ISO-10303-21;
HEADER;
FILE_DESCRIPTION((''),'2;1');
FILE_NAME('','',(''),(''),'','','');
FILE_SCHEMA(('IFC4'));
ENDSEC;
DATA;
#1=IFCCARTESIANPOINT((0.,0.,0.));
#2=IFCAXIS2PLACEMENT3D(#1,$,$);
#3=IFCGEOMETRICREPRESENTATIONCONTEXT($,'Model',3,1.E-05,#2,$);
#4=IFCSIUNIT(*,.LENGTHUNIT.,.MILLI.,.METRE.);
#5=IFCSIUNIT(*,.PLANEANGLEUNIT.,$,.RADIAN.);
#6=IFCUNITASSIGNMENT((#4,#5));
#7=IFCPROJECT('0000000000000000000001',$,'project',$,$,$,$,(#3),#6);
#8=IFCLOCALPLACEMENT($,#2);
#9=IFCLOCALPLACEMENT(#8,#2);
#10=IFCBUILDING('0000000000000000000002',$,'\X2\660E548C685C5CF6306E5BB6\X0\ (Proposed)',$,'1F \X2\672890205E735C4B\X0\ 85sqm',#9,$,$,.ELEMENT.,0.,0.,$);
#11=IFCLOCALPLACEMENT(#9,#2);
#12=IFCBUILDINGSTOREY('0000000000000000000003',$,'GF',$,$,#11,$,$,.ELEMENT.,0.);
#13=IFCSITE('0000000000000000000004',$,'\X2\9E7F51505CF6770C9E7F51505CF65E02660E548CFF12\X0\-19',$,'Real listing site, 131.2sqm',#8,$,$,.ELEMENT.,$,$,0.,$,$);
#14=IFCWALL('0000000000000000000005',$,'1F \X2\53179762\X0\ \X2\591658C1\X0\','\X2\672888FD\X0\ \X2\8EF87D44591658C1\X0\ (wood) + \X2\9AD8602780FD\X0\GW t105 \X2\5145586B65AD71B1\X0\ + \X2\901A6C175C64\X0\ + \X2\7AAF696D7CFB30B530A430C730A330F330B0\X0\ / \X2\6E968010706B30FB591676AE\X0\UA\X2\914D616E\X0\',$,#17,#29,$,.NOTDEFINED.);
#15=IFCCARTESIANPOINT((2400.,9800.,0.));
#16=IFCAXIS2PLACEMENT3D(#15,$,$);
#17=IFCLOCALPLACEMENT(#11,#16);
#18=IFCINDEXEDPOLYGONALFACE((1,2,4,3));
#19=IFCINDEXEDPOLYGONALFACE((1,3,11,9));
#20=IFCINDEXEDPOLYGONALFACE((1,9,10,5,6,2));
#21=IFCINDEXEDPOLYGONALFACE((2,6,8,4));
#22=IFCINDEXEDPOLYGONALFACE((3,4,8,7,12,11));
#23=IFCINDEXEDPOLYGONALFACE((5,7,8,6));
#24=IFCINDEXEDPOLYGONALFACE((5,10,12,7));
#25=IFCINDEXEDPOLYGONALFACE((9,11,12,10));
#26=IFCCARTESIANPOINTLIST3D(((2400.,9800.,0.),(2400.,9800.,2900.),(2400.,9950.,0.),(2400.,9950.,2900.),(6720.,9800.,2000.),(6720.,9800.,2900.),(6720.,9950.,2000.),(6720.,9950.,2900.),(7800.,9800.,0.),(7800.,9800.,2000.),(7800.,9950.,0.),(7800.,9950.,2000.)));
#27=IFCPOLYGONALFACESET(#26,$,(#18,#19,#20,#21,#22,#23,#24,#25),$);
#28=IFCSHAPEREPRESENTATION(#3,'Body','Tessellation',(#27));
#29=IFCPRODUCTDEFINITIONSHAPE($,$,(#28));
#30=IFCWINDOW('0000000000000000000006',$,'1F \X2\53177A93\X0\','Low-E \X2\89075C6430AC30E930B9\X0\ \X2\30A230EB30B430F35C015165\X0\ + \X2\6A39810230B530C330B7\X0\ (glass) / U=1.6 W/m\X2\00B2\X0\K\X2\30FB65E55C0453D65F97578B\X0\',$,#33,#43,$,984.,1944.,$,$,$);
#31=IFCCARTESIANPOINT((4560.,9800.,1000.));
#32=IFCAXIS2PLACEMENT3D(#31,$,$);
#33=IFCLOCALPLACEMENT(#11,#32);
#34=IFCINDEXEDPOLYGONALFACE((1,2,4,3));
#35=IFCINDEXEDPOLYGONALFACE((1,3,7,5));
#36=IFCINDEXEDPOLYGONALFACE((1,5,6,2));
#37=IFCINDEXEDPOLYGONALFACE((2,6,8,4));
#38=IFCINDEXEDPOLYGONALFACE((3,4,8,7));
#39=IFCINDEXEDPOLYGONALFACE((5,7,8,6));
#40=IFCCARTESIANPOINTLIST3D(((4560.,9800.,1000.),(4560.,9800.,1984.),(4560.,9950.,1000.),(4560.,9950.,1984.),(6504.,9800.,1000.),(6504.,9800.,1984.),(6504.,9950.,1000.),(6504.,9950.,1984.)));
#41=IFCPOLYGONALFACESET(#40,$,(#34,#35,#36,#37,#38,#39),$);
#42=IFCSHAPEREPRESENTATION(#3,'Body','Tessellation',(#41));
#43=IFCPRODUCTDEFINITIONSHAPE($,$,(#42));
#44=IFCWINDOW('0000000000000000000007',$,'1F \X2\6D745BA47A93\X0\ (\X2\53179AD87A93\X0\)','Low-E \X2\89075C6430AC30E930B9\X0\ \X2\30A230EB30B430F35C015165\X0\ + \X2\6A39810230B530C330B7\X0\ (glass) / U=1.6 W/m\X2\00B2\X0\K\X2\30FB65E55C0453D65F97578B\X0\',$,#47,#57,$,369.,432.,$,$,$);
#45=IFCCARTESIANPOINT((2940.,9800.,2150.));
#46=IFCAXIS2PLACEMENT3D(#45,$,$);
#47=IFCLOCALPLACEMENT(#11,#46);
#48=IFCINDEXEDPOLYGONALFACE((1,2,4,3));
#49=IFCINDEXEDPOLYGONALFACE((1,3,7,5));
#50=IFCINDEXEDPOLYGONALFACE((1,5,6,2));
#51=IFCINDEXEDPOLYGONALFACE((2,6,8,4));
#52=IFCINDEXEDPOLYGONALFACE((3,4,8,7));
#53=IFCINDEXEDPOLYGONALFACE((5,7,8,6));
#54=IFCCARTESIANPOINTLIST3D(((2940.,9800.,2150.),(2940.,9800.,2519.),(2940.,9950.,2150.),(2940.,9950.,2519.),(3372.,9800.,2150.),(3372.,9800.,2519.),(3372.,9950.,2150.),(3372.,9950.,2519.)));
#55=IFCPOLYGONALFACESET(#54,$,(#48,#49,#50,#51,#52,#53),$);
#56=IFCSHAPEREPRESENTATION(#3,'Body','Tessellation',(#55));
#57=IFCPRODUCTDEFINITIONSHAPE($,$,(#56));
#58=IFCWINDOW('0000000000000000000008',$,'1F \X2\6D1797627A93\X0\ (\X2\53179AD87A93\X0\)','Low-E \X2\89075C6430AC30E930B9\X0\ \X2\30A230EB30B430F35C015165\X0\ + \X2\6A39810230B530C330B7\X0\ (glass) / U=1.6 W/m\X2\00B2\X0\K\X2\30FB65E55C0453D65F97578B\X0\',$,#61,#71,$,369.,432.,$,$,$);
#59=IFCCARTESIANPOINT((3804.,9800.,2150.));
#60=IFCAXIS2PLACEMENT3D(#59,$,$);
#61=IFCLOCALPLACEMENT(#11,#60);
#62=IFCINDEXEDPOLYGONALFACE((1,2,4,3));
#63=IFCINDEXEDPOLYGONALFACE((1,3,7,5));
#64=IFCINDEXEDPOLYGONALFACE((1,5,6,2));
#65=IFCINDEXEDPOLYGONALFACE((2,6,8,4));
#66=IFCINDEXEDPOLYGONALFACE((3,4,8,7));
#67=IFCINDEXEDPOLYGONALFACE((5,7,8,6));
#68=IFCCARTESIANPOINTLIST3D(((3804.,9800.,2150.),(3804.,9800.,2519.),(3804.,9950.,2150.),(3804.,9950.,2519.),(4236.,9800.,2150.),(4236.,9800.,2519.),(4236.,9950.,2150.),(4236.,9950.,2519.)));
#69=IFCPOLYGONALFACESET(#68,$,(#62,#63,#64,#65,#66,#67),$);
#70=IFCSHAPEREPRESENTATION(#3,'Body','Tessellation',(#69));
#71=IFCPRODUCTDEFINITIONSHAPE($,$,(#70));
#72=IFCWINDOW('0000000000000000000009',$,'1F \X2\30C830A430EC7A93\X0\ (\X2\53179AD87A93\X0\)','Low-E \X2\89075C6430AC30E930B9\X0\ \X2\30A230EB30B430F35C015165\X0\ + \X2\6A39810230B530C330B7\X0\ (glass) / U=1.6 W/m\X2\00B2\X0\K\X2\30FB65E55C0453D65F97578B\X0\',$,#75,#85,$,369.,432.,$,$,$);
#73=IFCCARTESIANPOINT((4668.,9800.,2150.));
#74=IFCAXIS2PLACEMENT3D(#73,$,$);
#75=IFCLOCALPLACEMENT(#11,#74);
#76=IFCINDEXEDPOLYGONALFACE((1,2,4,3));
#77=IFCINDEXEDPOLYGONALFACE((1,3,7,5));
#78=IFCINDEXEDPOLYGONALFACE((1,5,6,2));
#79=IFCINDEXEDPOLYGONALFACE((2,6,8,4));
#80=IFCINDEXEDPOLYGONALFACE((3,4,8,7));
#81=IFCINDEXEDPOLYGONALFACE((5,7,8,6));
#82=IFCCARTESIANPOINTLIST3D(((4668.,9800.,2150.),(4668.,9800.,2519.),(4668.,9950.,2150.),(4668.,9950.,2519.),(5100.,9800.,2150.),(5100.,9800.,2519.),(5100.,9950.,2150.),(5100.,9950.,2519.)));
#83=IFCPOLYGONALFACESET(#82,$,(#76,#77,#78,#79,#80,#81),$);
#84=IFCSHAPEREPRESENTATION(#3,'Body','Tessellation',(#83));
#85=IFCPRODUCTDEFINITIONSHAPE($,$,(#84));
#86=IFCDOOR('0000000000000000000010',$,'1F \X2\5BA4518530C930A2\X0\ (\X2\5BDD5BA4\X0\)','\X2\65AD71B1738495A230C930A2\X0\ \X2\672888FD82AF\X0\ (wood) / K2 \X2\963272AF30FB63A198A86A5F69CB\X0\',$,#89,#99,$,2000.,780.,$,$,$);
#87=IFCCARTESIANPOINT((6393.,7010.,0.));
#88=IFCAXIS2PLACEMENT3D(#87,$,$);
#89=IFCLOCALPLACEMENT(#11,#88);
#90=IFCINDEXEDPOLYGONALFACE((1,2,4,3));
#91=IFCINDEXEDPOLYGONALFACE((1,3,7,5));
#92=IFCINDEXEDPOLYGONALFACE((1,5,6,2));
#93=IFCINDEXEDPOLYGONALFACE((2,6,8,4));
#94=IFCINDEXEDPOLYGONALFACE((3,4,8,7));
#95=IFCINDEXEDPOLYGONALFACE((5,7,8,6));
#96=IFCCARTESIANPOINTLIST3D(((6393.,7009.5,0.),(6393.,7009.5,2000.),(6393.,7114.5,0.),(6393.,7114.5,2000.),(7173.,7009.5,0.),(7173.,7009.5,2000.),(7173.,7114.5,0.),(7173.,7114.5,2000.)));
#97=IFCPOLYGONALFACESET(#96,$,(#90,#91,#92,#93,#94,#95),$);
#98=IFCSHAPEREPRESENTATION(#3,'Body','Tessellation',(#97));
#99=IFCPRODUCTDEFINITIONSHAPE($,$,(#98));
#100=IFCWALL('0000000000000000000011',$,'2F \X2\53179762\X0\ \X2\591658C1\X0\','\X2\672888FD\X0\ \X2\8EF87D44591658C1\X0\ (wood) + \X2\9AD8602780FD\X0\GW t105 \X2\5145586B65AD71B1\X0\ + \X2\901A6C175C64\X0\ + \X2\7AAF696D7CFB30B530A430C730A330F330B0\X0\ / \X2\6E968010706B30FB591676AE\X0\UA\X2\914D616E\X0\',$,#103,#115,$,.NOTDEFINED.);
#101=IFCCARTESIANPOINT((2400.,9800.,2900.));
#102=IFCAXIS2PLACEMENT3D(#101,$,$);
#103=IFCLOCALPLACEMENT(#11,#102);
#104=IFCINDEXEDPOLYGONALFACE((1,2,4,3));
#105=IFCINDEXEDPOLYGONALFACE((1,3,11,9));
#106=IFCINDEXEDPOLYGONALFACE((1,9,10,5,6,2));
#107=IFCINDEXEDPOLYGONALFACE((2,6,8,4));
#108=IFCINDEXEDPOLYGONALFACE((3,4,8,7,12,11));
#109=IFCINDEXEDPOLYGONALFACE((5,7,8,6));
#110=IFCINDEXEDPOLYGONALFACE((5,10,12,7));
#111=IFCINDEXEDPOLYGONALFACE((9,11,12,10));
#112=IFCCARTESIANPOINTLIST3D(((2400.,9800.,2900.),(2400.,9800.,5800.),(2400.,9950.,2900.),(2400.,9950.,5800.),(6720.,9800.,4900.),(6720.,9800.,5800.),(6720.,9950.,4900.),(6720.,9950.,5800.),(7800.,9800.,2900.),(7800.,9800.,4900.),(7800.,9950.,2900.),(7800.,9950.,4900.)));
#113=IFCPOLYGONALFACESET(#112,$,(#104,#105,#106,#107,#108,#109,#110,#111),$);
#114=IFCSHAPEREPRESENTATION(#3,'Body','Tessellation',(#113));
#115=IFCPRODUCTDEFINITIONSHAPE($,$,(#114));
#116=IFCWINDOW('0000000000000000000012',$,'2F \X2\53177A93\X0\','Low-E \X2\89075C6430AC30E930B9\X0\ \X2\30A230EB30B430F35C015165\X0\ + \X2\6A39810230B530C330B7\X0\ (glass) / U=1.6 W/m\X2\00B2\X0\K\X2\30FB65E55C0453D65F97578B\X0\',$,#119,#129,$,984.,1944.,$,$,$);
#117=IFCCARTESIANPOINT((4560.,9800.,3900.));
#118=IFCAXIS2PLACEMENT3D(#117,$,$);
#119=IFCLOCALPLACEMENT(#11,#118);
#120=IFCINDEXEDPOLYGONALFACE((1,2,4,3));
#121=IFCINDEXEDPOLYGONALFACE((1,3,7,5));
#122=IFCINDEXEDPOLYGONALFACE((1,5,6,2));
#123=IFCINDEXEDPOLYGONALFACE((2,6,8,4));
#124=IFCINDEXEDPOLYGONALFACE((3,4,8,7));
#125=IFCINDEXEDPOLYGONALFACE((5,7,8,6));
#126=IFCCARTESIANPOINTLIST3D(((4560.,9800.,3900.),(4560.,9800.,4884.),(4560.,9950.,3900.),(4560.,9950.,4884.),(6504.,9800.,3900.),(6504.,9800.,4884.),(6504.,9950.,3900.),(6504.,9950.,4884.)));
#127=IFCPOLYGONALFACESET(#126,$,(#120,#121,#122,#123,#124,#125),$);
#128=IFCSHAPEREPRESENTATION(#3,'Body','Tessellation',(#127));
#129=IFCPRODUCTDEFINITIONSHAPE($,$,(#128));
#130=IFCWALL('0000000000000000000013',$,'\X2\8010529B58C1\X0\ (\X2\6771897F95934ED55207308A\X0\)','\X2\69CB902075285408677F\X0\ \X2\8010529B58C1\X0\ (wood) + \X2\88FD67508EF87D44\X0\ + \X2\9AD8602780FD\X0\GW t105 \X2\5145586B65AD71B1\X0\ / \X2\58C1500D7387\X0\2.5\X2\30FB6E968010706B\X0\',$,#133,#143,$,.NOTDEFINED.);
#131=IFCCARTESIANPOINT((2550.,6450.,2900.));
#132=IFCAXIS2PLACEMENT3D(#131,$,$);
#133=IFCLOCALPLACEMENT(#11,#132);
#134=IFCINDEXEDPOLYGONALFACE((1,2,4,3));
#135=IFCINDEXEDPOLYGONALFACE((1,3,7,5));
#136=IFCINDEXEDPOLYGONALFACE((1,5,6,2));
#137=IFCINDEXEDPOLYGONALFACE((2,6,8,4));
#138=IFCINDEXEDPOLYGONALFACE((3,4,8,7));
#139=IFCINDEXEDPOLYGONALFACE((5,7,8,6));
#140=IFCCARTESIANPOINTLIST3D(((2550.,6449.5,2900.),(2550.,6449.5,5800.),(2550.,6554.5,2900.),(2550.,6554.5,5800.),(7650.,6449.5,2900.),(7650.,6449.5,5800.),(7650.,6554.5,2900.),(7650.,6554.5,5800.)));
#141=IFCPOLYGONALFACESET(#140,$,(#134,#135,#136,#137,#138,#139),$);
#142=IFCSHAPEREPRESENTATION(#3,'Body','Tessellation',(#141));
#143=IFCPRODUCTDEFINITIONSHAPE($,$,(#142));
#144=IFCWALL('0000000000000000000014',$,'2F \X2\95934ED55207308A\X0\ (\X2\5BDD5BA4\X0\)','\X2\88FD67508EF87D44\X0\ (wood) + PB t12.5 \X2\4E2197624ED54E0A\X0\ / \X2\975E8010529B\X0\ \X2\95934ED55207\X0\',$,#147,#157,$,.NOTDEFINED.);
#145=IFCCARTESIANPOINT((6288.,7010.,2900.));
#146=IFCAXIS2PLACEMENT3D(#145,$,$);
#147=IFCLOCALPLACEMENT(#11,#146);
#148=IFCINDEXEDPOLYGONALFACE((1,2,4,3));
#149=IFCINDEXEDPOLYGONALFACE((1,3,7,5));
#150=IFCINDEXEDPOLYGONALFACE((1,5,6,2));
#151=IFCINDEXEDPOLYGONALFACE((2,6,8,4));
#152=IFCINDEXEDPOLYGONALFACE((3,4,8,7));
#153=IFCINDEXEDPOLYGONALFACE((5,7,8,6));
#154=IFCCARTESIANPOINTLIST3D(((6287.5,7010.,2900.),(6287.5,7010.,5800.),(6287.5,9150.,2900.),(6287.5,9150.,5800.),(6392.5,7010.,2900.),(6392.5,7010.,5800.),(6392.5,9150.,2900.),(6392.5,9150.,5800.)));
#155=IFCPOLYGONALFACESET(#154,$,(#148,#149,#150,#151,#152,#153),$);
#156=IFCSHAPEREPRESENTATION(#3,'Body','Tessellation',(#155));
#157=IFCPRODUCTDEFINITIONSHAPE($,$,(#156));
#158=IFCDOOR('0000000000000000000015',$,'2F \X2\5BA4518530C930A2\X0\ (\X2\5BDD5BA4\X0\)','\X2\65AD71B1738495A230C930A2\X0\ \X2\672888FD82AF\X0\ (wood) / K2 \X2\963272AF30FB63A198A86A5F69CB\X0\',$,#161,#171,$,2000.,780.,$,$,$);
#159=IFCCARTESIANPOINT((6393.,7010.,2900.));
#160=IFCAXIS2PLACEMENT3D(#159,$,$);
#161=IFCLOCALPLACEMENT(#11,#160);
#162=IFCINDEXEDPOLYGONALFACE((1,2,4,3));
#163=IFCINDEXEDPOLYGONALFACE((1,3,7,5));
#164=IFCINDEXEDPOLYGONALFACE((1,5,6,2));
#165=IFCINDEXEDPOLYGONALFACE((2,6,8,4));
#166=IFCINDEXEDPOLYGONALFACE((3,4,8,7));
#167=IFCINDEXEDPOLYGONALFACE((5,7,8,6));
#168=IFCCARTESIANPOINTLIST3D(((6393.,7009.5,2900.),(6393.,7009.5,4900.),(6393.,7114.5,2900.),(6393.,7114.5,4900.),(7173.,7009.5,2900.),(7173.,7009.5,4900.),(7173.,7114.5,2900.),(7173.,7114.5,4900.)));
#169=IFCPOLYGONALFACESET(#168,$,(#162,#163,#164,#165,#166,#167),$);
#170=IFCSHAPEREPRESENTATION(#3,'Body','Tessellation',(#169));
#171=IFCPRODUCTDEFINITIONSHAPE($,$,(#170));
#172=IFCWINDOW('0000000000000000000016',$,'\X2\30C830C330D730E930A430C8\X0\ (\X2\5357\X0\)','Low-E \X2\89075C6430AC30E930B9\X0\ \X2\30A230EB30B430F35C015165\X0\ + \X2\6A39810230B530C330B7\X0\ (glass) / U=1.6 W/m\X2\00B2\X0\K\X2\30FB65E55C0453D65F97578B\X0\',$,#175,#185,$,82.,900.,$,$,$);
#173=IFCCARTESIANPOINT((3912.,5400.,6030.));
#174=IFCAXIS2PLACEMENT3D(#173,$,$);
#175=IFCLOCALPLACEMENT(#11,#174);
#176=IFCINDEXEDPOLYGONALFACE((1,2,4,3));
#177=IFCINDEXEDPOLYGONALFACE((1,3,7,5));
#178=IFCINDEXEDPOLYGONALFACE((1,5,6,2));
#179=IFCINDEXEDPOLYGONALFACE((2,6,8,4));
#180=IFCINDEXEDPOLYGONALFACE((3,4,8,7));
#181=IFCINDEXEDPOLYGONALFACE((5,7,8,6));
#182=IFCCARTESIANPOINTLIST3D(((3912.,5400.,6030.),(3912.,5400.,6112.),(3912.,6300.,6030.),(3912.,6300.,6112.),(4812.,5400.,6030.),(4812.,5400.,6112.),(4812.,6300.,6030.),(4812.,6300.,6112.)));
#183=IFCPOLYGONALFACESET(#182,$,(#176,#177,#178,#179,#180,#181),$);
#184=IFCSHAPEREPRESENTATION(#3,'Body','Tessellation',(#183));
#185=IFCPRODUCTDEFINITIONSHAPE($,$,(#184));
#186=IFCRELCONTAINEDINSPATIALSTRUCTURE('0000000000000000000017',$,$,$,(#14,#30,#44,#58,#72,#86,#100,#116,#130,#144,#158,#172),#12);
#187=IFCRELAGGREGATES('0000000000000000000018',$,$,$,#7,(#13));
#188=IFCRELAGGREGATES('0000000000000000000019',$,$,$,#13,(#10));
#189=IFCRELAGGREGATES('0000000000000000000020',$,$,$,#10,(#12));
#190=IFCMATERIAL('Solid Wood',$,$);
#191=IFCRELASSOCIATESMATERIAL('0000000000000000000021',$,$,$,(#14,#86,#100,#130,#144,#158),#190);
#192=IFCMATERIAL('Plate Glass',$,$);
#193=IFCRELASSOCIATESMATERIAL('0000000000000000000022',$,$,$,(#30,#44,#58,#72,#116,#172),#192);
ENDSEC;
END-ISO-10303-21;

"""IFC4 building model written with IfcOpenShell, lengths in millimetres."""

from ifc_helpers import new_model, si_unit, frame, frame_2d, origin, place, context, project, spatial, rectangle, extrude, material, element, fill, save


model = new_model("IFC4")

# Units and contexts
model_context = context("Model", 3, precision=1e-05, world=origin())
ifc_project = project(units=[si_unit("LENGTHUNIT", "METRE", prefix="MILLI"), si_unit("PLANEANGLEUNIT", "RADIAN")], contexts=[model_context])

# Site, building, storey
site_placement = place(None, origin())
site = spatial("IfcSite", under=ifc_project, at=site_placement, Name="鹿児島県鹿児島市明和２-19", ObjectType="Real listing site, 131.2sqm", CompositionType="ELEMENT", RefElevation=0.0)
building_placement = place(site_placement, origin())
building = spatial("IfcBuilding", under=site, at=building_placement, Name="明和桜島の家 (Proposed)", ObjectType="1F 木造平屋 85sqm", CompositionType="ELEMENT", ElevationOfRefHeight=0.0, ElevationOfTerrain=0.0)
storey_placement = place(building_placement, origin())
storey = spatial("IfcBuildingStorey", under=building, at=storey_placement, Name="GF", CompositionType="ELEMENT", Elevation=0.0)

# Wall, openings, windows
ifc_material_1 = material(Name="Solid Wood")
wall_1_placement = place(storey_placement, frame((2400.0, 9800.0, 0.0)))
wall_1 = element("IfcWall", 1, at=wall_1_placement, inside=storey, material=ifc_material_1, Name="1F 北面 外壁", Description="木製 軸組外壁 (wood) + 高性能GW t105 充填断熱 + 通気層 + 窯業系サイディング / 準耐火・外皮UA配慮", PredefinedType="NOTDEFINED", context=model_context, shape_type="SweptSolid", body=[
    extrude(rectangle(XDim=5400.0, YDim=150.0, at=frame_2d((2700.0, 75.0))), frame((2400.0, 9800.0, 0.0)), (0.0, 0.0, 1.0), 2900.0),
])
opening_1_placement = place(storey_placement, frame((4560.0, 9800.0, 1000.0)))
opening_1 = element("IfcOpeningElement", 2, at=opening_1_placement, cuts=wall_1, PredefinedType="NOTDEFINED", context=model_context, shape_type="SweptSolid", body=[
    extrude(rectangle(XDim=1944.0, YDim=150.0, at=frame_2d((972.0, 75.0))), frame((4560.0, 9800.0, 1000.0)), (0.0, 0.0, 1.0), 984.0),
])
opening_2_placement = place(storey_placement, frame((2940.0, 9800.0, 2150.0)))
opening_2 = element("IfcOpeningElement", 3, at=opening_2_placement, cuts=wall_1, PredefinedType="NOTDEFINED", context=model_context, shape_type="SweptSolid", body=[
    extrude(rectangle(XDim=432.0, YDim=150.0, at=frame_2d((216.0, 75.0))), frame((2940.0, 9800.0, 2150.0)), (0.0, 0.0, 1.0), 369.0),
])
opening_3_placement = place(storey_placement, frame((3804.0, 9800.0, 2150.0)))
opening_3 = element("IfcOpeningElement", 4, at=opening_3_placement, cuts=wall_1, PredefinedType="NOTDEFINED", context=model_context, shape_type="SweptSolid", body=[
    extrude(rectangle(XDim=432.0, YDim=150.0, at=frame_2d((216.0, 75.0))), frame((3804.0, 9800.0, 2150.0)), (0.0, 0.0, 1.0), 369.0),
])
opening_4_placement = place(storey_placement, frame((4668.0, 9800.0, 2150.0)))
opening_4 = element("IfcOpeningElement", 5, at=opening_4_placement, cuts=wall_1, PredefinedType="NOTDEFINED", context=model_context, shape_type="SweptSolid", body=[
    extrude(rectangle(XDim=432.0, YDim=150.0, at=frame_2d((216.0, 75.0))), frame((4668.0, 9800.0, 2150.0)), (0.0, 0.0, 1.0), 369.0),
])
ifc_material_2 = material(Name="Plate Glass")
window_1_placement = place(storey_placement, frame((4560.0, 9800.0, 1000.0)))
window_1 = element("IfcWindow", 6, at=window_1_placement, inside=storey, material=ifc_material_2, Name="1F 北窓", Description="Low-E 複層ガラス アルゴン封入 + 樹脂サッシ (glass) / U=1.6 W/m²K・日射取得型", OverallHeight=984.0, OverallWidth=1944.0, context=model_context, shape_type="SweptSolid", body=[
    extrude(rectangle(XDim=1944.0, YDim=150.0, at=frame_2d((972.0, 75.0))), frame((4560.0, 9800.0, 1000.0)), (0.0, 0.0, 1.0), 984.0),
])
fill(opening_1, window_1)
window_2_placement = place(storey_placement, frame((2940.0, 9800.0, 2150.0)))
window_2 = element("IfcWindow", 7, at=window_2_placement, inside=storey, material=ifc_material_2, Name="1F 浴室窓 (北高窓)", Description="Low-E 複層ガラス アルゴン封入 + 樹脂サッシ (glass) / U=1.6 W/m²K・日射取得型", OverallHeight=369.0, OverallWidth=432.0, context=model_context, shape_type="SweptSolid", body=[
    extrude(rectangle(XDim=432.0, YDim=150.0, at=frame_2d((216.0, 75.0))), frame((2940.0, 9800.0, 2150.0)), (0.0, 0.0, 1.0), 369.0),
])
fill(opening_2, window_2)
window_3_placement = place(storey_placement, frame((3804.0, 9800.0, 2150.0)))
window_3 = element("IfcWindow", 8, at=window_3_placement, inside=storey, material=ifc_material_2, Name="1F 洗面窓 (北高窓)", Description="Low-E 複層ガラス アルゴン封入 + 樹脂サッシ (glass) / U=1.6 W/m²K・日射取得型", OverallHeight=369.0, OverallWidth=432.0, context=model_context, shape_type="SweptSolid", body=[
    extrude(rectangle(XDim=432.0, YDim=150.0, at=frame_2d((216.0, 75.0))), frame((3804.0, 9800.0, 2150.0)), (0.0, 0.0, 1.0), 369.0),
])
fill(opening_3, window_3)
window_4_placement = place(storey_placement, frame((4668.0, 9800.0, 2150.0)))
window_4 = element("IfcWindow", 9, at=window_4_placement, inside=storey, material=ifc_material_2, Name="1F トイレ窓 (北高窓)", Description="Low-E 複層ガラス アルゴン封入 + 樹脂サッシ (glass) / U=1.6 W/m²K・日射取得型", OverallHeight=369.0, OverallWidth=432.0, context=model_context, shape_type="SweptSolid", body=[
    extrude(rectangle(XDim=432.0, YDim=150.0, at=frame_2d((216.0, 75.0))), frame((4668.0, 9800.0, 2150.0)), (0.0, 0.0, 1.0), 369.0),
])
fill(opening_4, window_4)

# Door
door_1_placement = place(storey_placement, frame((6393.0, 7010.0, 0.0)))
element("IfcDoor", 10, at=door_1_placement, inside=storey, material=ifc_material_1, Name="1F 室内ドア (寝室)", Description="断熱玄関ドア 木製芯 (wood) / K2 防犯・採風機構", OverallHeight=2000.0, OverallWidth=780.0, context=model_context, shape_type="SweptSolid", body=[
    extrude(rectangle(XDim=780.0, YDim=105.0, at=frame_2d((390.0, 52.0))), frame((6393.0, 7010.0, 0.0)), (0.0, 0.0, 1.0), 2000.0),
])

# Wall, opening, window
wall_2_placement = place(storey_placement, frame((2400.0, 9800.0, 2900.0)))
wall_2 = element("IfcWall", 11, at=wall_2_placement, inside=storey, material=ifc_material_1, Name="2F 北面 外壁", Description="木製 軸組外壁 (wood) + 高性能GW t105 充填断熱 + 通気層 + 窯業系サイディング / 準耐火・外皮UA配慮", PredefinedType="NOTDEFINED", context=model_context, shape_type="SweptSolid", body=[
    extrude(rectangle(XDim=5400.0, YDim=150.0, at=frame_2d((2700.0, 75.0))), frame((2400.0, 9800.0, 2900.0)), (0.0, 0.0, 1.0), 2900.0),
])
opening_5_placement = place(storey_placement, frame((4560.0, 9800.0, 3900.0)))
opening_5 = element("IfcOpeningElement", 12, at=opening_5_placement, cuts=wall_2, PredefinedType="NOTDEFINED", context=model_context, shape_type="SweptSolid", body=[
    extrude(rectangle(XDim=1944.0, YDim=150.0, at=frame_2d((972.0, 75.0))), frame((4560.0, 9800.0, 3900.0)), (0.0, 0.0, 1.0), 984.0),
])
window_5_placement = place(storey_placement, frame((4560.0, 9800.0, 3900.0)))
window_5 = element("IfcWindow", 13, at=window_5_placement, inside=storey, material=ifc_material_2, Name="2F 北窓", Description="Low-E 複層ガラス アルゴン封入 + 樹脂サッシ (glass) / U=1.6 W/m²K・日射取得型", OverallHeight=984.0, OverallWidth=1944.0, context=model_context, shape_type="SweptSolid", body=[
    extrude(rectangle(XDim=1944.0, YDim=150.0, at=frame_2d((972.0, 75.0))), frame((4560.0, 9800.0, 3900.0)), (0.0, 0.0, 1.0), 984.0),
])
fill(opening_5, window_5)

# Walls
wall_3_placement = place(storey_placement, frame((2550.0, 6450.0, 2900.0)))
element("IfcWall", 14, at=wall_3_placement, inside=storey, material=ifc_material_1, Name="耐力壁 (東西間仕切り)", Description="構造用合板 耐力壁 (wood) + 製材軸組 + 高性能GW t105 充填断熱 / 壁倍率2.5・準耐火", PredefinedType="NOTDEFINED", context=model_context, shape_type="SweptSolid", body=[
    extrude(rectangle(XDim=5100.0, YDim=105.0, at=frame_2d((2550.0, 52.0))), frame((2550.0, 6450.0, 2900.0)), (0.0, 0.0, 1.0), 2900.0),
])
wall_4_placement = place(storey_placement, frame((6288.0, 7010.0, 2900.0)))
element("IfcWall", 15, at=wall_4_placement, inside=storey, material=ifc_material_1, Name="2F 間仕切り (寝室)", Description="製材軸組 (wood) + PB t12.5 両面仕上 / 非耐力 間仕切", PredefinedType="NOTDEFINED", context=model_context, shape_type="SweptSolid", body=[
    extrude(rectangle(XDim=105.0, YDim=2140.0, at=frame_2d((52.0, 1070.0))), frame((6288.0, 7010.0, 2900.0)), (0.0, 0.0, 1.0), 2900.0),
])

# Door
door_2_placement = place(storey_placement, frame((6393.0, 7010.0, 2900.0)))
element("IfcDoor", 16, at=door_2_placement, inside=storey, material=ifc_material_1, Name="2F 室内ドア (寝室)", Description="断熱玄関ドア 木製芯 (wood) / K2 防犯・採風機構", OverallHeight=2000.0, OverallWidth=780.0, context=model_context, shape_type="SweptSolid", body=[
    extrude(rectangle(XDim=780.0, YDim=105.0, at=frame_2d((390.0, 52.0))), frame((6393.0, 7010.0, 2900.0)), (0.0, 0.0, 1.0), 2000.0),
])

# Window
window_6_placement = place(storey_placement, frame((3912.0, 5400.0, 6030.0)))
element("IfcWindow", 17, at=window_6_placement, inside=storey, material=ifc_material_2, Name="トップライト (南)", Description="Low-E 複層ガラス アルゴン封入 + 樹脂サッシ (glass) / U=1.6 W/m²K・日射取得型", OverallHeight=82.0, OverallWidth=900.0, context=model_context, shape_type="SweptSolid", body=[
    extrude(rectangle(XDim=900.0, YDim=900.0, at=frame_2d((450.0, 450.0))), frame((3912.0, 5400.0, 6030.0)), (0.0, 0.0, 1.0), 82.0),
])

save(model, "model.ifc")
